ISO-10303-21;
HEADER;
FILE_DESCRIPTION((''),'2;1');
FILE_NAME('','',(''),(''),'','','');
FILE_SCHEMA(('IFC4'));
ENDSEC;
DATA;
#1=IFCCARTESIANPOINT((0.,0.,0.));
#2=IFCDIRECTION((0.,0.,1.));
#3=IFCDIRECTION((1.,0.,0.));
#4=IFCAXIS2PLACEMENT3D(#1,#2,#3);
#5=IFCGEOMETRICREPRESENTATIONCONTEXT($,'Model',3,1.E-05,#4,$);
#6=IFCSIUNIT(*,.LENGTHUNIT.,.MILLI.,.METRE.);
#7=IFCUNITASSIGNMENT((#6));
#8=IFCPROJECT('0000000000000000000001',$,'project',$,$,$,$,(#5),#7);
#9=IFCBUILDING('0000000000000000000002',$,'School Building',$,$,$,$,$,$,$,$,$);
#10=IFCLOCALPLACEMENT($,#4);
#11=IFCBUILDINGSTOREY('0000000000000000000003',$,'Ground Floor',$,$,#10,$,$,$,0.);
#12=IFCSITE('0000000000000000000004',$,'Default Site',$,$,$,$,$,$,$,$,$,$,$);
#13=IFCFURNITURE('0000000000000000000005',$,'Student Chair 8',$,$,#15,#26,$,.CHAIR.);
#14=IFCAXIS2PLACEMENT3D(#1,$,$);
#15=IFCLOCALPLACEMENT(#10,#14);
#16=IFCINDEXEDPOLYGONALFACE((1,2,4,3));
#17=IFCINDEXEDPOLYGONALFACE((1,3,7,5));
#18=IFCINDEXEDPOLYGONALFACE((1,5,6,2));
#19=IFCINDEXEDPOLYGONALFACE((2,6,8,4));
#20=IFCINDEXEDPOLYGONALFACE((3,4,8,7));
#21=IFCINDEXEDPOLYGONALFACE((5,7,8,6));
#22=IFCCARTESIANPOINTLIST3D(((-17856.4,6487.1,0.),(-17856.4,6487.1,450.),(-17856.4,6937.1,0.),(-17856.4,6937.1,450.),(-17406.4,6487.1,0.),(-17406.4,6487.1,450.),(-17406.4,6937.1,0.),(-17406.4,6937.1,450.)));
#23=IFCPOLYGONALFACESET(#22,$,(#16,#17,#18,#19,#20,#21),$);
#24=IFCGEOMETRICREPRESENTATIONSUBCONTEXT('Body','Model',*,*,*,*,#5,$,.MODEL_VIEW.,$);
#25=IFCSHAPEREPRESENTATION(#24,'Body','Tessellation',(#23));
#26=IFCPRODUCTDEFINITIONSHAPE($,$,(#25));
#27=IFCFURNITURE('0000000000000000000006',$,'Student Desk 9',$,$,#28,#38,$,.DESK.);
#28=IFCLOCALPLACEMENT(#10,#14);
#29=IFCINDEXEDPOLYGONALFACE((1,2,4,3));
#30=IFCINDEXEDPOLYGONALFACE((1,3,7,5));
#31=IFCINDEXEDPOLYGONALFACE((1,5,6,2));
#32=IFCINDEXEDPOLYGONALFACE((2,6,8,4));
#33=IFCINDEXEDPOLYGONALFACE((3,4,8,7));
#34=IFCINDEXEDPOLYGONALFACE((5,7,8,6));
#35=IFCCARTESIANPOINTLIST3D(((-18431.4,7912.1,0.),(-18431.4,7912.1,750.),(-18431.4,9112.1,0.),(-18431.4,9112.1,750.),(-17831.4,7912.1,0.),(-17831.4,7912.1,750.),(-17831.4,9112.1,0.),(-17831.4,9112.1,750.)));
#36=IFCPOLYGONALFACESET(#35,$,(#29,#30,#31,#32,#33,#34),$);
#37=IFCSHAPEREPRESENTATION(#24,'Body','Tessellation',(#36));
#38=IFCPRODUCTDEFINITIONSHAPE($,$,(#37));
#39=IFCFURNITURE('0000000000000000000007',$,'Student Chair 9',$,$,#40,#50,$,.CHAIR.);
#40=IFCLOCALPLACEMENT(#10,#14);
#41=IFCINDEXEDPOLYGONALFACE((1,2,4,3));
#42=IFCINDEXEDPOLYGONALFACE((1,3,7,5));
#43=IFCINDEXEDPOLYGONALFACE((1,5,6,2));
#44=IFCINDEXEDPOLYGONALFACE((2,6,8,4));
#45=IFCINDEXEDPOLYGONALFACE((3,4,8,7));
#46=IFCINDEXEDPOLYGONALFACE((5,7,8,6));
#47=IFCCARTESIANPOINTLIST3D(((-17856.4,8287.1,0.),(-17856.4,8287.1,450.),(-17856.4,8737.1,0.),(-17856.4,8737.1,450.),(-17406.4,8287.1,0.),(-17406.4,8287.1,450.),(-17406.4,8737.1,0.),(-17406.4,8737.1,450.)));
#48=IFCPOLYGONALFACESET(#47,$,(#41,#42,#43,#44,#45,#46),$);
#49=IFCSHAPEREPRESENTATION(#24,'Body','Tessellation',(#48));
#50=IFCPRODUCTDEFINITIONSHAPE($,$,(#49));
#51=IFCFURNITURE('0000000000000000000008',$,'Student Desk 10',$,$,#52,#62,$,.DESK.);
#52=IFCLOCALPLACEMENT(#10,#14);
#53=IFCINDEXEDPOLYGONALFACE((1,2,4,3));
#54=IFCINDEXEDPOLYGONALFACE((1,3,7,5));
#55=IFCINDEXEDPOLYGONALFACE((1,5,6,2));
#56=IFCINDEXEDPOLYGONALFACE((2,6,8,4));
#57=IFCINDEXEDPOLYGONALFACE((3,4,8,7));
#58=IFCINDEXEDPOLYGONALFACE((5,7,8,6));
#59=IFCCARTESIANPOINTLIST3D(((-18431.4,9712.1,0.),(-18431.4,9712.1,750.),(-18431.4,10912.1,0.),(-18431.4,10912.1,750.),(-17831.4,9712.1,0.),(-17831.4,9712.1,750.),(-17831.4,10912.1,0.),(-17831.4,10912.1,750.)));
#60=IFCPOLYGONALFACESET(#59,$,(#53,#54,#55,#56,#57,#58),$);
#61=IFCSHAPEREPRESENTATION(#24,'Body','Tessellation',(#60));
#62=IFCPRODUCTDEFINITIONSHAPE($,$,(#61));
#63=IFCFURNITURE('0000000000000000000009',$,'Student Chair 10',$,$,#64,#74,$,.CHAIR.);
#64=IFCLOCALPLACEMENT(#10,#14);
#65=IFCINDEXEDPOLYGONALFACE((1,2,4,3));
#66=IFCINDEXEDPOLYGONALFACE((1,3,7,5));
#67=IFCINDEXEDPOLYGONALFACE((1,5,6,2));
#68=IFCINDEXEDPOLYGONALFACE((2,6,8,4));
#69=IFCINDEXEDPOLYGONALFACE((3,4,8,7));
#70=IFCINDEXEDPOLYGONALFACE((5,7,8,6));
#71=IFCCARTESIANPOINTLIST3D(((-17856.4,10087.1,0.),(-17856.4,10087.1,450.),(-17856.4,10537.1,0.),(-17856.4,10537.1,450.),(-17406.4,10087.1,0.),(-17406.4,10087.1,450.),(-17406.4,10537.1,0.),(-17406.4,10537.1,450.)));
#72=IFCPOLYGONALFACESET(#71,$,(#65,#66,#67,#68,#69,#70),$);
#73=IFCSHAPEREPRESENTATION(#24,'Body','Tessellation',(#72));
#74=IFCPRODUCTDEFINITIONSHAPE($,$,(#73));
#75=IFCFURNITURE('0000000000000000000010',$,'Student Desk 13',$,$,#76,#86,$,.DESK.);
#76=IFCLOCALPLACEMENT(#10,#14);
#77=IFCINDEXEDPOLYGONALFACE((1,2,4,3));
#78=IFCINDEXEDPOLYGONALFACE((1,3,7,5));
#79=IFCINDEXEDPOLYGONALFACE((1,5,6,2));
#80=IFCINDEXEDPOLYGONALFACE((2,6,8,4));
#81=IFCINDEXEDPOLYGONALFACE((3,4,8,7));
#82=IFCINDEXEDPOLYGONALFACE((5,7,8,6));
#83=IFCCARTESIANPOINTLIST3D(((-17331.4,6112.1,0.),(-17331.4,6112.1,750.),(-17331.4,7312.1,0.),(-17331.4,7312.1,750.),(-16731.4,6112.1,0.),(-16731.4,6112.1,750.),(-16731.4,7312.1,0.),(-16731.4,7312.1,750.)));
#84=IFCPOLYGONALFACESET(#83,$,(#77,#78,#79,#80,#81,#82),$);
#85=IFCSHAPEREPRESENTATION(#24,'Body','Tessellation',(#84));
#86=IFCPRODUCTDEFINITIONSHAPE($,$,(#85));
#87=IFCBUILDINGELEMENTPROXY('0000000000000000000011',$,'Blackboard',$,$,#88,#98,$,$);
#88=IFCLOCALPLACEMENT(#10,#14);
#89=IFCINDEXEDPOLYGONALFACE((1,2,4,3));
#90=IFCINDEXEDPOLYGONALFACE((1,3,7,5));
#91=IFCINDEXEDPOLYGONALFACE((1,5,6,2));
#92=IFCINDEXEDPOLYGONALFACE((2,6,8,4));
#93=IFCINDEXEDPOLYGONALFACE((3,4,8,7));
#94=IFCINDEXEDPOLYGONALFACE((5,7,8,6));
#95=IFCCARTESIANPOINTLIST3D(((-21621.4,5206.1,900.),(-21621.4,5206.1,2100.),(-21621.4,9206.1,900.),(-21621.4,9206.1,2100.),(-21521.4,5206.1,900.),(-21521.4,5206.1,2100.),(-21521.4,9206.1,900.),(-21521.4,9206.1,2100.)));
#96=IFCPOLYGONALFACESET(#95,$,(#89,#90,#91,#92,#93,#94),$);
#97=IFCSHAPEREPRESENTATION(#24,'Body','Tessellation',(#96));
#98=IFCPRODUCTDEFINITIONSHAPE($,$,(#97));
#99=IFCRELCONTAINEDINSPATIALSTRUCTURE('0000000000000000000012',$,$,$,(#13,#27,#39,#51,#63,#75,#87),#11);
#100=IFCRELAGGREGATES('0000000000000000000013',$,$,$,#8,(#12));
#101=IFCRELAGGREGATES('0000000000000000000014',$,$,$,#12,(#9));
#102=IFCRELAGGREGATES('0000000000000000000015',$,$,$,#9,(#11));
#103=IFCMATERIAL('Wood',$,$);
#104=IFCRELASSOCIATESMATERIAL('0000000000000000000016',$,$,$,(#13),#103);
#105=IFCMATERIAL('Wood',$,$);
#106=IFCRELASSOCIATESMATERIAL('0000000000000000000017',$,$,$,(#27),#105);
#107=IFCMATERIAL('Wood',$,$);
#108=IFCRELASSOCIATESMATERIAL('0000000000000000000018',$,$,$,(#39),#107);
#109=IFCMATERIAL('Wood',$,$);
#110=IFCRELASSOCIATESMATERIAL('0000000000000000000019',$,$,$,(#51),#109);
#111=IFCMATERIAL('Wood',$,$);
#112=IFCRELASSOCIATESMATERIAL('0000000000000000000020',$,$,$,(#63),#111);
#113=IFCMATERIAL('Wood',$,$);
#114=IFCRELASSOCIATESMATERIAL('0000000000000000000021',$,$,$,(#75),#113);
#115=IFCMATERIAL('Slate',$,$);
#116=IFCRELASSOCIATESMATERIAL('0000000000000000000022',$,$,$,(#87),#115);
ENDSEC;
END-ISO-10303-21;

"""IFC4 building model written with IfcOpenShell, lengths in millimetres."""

from ifc_helpers import new_model, si_unit, frame, origin_with_axes, origin_2d, place, context, subcontext, project, spatial, rectangle, extrude, material, element, save


model = new_model("IFC4")

# Units and contexts
model_context = context("Model", 3, precision=1e-05, world=origin_with_axes())
body_context = subcontext(model_context, "Body", "Model", "MODEL_VIEW")
ifc_project = project(units=[si_unit("LENGTHUNIT", "METRE", prefix="MILLI")], contexts=[model_context])

# Site, building, storey
site = spatial("IfcSite", under=ifc_project, Name="Default Site")
building = spatial("IfcBuilding", under=site, Name="School Building")
storey_placement = place(None, origin_with_axes())
storey = spatial("IfcBuildingStorey", under=building, at=storey_placement, Name="Ground Floor", Elevation=0.0)

# Furniture
ifc_material_1 = material(Name="Wood")
furniture_1_placement = place(storey_placement, frame((-17631.4, 6712.1, 0.0), z_axis=(0.0, 0.0, 1.0), x_axis=(1.0, 0.0, 0.0)))
element("IfcFurniture", 1, at=furniture_1_placement, inside=storey, material=ifc_material_1, Name="Student Chair 8", PredefinedType="CHAIR", context=body_context, shape_type="SweptSolid", body=[
    extrude(rectangle(XDim=450.0, YDim=450.0, at=origin_2d()), origin_with_axes(), (0.0, 0.0, 1.0), 450.0),
])
ifc_material_2 = material(Name="Wood")
furniture_2_placement = place(storey_placement, frame((-18131.4, 8512.1, 0.0), z_axis=(0.0, 0.0, 1.0), x_axis=(0.0, 1.0, 0.0)))
element("IfcFurniture", 2, at=furniture_2_placement, inside=storey, material=ifc_material_2, Name="Student Desk 9", PredefinedType="DESK", context=body_context, shape_type="SweptSolid", body=[
    extrude(rectangle(XDim=1200.0, YDim=600.0, at=origin_2d()), origin_with_axes(), (0.0, 0.0, 1.0), 750.0),
])
ifc_material_3 = material(Name="Wood")
furniture_3_placement = place(storey_placement, frame((-17631.4, 8512.1, 0.0), z_axis=(0.0, 0.0, 1.0), x_axis=(1.0, 0.0, 0.0)))
element("IfcFurniture", 3, at=furniture_3_placement, inside=storey, material=ifc_material_3, Name="Student Chair 9", PredefinedType="CHAIR", context=body_context, shape_type="SweptSolid", body=[
    extrude(rectangle(XDim=450.0, YDim=450.0, at=origin_2d()), origin_with_axes(), (0.0, 0.0, 1.0), 450.0),
])
ifc_material_4 = material(Name="Wood")
furniture_4_placement = place(storey_placement, frame((-18131.4, 10312.1, 0.0), z_axis=(0.0, 0.0, 1.0), x_axis=(0.0, 1.0, 0.0)))
element("IfcFurniture", 4, at=furniture_4_placement, inside=storey, material=ifc_material_4, Name="Student Desk 10", PredefinedType="DESK", context=body_context, shape_type="SweptSolid", body=[
    extrude(rectangle(XDim=1200.0, YDim=600.0, at=origin_2d()), origin_with_axes(), (0.0, 0.0, 1.0), 750.0),
])
ifc_material_5 = material(Name="Wood")
furniture_5_placement = place(storey_placement, frame((-17631.4, 10312.1, 0.0), z_axis=(0.0, 0.0, 1.0), x_axis=(1.0, 0.0, 0.0)))
element("IfcFurniture", 5, at=furniture_5_placement, inside=storey, material=ifc_material_5, Name="Student Chair 10", PredefinedType="CHAIR", context=body_context, shape_type="SweptSolid", body=[
    extrude(rectangle(XDim=450.0, YDim=450.0, at=origin_2d()), origin_with_axes(), (0.0, 0.0, 1.0), 450.0),
])
ifc_material_6 = material(Name="Wood")
furniture_6_placement = place(storey_placement, frame((-17031.4, 6712.1, 0.0), z_axis=(0.0, 0.0, 1.0), x_axis=(0.0, 1.0, 0.0)))
element("IfcFurniture", 6, at=furniture_6_placement, inside=storey, material=ifc_material_6, Name="Student Desk 13", PredefinedType="DESK", context=body_context, shape_type="SweptSolid", body=[
    extrude(rectangle(XDim=1200.0, YDim=600.0, at=origin_2d()), origin_with_axes(), (0.0, 0.0, 1.0), 750.0),
])

# Building element proxy
ifc_material_7 = material(Name="Slate")
proxy_placement = place(storey_placement, frame((-21571.4, 7206.1, 900.0), z_axis=(0.0, 0.0, 1.0), x_axis=(1.0, 0.0, 0.0)))
element("IfcBuildingElementProxy", 7, at=proxy_placement, inside=storey, material=ifc_material_7, Name="Blackboard", context=body_context, shape_type="SweptSolid", body=[
    extrude(rectangle(XDim=100.0, YDim=4000.0, at=origin_2d()), origin_with_axes(), (0.0, 0.0, 1.0), 1200.0),
])

save(model, "model.ifc")
